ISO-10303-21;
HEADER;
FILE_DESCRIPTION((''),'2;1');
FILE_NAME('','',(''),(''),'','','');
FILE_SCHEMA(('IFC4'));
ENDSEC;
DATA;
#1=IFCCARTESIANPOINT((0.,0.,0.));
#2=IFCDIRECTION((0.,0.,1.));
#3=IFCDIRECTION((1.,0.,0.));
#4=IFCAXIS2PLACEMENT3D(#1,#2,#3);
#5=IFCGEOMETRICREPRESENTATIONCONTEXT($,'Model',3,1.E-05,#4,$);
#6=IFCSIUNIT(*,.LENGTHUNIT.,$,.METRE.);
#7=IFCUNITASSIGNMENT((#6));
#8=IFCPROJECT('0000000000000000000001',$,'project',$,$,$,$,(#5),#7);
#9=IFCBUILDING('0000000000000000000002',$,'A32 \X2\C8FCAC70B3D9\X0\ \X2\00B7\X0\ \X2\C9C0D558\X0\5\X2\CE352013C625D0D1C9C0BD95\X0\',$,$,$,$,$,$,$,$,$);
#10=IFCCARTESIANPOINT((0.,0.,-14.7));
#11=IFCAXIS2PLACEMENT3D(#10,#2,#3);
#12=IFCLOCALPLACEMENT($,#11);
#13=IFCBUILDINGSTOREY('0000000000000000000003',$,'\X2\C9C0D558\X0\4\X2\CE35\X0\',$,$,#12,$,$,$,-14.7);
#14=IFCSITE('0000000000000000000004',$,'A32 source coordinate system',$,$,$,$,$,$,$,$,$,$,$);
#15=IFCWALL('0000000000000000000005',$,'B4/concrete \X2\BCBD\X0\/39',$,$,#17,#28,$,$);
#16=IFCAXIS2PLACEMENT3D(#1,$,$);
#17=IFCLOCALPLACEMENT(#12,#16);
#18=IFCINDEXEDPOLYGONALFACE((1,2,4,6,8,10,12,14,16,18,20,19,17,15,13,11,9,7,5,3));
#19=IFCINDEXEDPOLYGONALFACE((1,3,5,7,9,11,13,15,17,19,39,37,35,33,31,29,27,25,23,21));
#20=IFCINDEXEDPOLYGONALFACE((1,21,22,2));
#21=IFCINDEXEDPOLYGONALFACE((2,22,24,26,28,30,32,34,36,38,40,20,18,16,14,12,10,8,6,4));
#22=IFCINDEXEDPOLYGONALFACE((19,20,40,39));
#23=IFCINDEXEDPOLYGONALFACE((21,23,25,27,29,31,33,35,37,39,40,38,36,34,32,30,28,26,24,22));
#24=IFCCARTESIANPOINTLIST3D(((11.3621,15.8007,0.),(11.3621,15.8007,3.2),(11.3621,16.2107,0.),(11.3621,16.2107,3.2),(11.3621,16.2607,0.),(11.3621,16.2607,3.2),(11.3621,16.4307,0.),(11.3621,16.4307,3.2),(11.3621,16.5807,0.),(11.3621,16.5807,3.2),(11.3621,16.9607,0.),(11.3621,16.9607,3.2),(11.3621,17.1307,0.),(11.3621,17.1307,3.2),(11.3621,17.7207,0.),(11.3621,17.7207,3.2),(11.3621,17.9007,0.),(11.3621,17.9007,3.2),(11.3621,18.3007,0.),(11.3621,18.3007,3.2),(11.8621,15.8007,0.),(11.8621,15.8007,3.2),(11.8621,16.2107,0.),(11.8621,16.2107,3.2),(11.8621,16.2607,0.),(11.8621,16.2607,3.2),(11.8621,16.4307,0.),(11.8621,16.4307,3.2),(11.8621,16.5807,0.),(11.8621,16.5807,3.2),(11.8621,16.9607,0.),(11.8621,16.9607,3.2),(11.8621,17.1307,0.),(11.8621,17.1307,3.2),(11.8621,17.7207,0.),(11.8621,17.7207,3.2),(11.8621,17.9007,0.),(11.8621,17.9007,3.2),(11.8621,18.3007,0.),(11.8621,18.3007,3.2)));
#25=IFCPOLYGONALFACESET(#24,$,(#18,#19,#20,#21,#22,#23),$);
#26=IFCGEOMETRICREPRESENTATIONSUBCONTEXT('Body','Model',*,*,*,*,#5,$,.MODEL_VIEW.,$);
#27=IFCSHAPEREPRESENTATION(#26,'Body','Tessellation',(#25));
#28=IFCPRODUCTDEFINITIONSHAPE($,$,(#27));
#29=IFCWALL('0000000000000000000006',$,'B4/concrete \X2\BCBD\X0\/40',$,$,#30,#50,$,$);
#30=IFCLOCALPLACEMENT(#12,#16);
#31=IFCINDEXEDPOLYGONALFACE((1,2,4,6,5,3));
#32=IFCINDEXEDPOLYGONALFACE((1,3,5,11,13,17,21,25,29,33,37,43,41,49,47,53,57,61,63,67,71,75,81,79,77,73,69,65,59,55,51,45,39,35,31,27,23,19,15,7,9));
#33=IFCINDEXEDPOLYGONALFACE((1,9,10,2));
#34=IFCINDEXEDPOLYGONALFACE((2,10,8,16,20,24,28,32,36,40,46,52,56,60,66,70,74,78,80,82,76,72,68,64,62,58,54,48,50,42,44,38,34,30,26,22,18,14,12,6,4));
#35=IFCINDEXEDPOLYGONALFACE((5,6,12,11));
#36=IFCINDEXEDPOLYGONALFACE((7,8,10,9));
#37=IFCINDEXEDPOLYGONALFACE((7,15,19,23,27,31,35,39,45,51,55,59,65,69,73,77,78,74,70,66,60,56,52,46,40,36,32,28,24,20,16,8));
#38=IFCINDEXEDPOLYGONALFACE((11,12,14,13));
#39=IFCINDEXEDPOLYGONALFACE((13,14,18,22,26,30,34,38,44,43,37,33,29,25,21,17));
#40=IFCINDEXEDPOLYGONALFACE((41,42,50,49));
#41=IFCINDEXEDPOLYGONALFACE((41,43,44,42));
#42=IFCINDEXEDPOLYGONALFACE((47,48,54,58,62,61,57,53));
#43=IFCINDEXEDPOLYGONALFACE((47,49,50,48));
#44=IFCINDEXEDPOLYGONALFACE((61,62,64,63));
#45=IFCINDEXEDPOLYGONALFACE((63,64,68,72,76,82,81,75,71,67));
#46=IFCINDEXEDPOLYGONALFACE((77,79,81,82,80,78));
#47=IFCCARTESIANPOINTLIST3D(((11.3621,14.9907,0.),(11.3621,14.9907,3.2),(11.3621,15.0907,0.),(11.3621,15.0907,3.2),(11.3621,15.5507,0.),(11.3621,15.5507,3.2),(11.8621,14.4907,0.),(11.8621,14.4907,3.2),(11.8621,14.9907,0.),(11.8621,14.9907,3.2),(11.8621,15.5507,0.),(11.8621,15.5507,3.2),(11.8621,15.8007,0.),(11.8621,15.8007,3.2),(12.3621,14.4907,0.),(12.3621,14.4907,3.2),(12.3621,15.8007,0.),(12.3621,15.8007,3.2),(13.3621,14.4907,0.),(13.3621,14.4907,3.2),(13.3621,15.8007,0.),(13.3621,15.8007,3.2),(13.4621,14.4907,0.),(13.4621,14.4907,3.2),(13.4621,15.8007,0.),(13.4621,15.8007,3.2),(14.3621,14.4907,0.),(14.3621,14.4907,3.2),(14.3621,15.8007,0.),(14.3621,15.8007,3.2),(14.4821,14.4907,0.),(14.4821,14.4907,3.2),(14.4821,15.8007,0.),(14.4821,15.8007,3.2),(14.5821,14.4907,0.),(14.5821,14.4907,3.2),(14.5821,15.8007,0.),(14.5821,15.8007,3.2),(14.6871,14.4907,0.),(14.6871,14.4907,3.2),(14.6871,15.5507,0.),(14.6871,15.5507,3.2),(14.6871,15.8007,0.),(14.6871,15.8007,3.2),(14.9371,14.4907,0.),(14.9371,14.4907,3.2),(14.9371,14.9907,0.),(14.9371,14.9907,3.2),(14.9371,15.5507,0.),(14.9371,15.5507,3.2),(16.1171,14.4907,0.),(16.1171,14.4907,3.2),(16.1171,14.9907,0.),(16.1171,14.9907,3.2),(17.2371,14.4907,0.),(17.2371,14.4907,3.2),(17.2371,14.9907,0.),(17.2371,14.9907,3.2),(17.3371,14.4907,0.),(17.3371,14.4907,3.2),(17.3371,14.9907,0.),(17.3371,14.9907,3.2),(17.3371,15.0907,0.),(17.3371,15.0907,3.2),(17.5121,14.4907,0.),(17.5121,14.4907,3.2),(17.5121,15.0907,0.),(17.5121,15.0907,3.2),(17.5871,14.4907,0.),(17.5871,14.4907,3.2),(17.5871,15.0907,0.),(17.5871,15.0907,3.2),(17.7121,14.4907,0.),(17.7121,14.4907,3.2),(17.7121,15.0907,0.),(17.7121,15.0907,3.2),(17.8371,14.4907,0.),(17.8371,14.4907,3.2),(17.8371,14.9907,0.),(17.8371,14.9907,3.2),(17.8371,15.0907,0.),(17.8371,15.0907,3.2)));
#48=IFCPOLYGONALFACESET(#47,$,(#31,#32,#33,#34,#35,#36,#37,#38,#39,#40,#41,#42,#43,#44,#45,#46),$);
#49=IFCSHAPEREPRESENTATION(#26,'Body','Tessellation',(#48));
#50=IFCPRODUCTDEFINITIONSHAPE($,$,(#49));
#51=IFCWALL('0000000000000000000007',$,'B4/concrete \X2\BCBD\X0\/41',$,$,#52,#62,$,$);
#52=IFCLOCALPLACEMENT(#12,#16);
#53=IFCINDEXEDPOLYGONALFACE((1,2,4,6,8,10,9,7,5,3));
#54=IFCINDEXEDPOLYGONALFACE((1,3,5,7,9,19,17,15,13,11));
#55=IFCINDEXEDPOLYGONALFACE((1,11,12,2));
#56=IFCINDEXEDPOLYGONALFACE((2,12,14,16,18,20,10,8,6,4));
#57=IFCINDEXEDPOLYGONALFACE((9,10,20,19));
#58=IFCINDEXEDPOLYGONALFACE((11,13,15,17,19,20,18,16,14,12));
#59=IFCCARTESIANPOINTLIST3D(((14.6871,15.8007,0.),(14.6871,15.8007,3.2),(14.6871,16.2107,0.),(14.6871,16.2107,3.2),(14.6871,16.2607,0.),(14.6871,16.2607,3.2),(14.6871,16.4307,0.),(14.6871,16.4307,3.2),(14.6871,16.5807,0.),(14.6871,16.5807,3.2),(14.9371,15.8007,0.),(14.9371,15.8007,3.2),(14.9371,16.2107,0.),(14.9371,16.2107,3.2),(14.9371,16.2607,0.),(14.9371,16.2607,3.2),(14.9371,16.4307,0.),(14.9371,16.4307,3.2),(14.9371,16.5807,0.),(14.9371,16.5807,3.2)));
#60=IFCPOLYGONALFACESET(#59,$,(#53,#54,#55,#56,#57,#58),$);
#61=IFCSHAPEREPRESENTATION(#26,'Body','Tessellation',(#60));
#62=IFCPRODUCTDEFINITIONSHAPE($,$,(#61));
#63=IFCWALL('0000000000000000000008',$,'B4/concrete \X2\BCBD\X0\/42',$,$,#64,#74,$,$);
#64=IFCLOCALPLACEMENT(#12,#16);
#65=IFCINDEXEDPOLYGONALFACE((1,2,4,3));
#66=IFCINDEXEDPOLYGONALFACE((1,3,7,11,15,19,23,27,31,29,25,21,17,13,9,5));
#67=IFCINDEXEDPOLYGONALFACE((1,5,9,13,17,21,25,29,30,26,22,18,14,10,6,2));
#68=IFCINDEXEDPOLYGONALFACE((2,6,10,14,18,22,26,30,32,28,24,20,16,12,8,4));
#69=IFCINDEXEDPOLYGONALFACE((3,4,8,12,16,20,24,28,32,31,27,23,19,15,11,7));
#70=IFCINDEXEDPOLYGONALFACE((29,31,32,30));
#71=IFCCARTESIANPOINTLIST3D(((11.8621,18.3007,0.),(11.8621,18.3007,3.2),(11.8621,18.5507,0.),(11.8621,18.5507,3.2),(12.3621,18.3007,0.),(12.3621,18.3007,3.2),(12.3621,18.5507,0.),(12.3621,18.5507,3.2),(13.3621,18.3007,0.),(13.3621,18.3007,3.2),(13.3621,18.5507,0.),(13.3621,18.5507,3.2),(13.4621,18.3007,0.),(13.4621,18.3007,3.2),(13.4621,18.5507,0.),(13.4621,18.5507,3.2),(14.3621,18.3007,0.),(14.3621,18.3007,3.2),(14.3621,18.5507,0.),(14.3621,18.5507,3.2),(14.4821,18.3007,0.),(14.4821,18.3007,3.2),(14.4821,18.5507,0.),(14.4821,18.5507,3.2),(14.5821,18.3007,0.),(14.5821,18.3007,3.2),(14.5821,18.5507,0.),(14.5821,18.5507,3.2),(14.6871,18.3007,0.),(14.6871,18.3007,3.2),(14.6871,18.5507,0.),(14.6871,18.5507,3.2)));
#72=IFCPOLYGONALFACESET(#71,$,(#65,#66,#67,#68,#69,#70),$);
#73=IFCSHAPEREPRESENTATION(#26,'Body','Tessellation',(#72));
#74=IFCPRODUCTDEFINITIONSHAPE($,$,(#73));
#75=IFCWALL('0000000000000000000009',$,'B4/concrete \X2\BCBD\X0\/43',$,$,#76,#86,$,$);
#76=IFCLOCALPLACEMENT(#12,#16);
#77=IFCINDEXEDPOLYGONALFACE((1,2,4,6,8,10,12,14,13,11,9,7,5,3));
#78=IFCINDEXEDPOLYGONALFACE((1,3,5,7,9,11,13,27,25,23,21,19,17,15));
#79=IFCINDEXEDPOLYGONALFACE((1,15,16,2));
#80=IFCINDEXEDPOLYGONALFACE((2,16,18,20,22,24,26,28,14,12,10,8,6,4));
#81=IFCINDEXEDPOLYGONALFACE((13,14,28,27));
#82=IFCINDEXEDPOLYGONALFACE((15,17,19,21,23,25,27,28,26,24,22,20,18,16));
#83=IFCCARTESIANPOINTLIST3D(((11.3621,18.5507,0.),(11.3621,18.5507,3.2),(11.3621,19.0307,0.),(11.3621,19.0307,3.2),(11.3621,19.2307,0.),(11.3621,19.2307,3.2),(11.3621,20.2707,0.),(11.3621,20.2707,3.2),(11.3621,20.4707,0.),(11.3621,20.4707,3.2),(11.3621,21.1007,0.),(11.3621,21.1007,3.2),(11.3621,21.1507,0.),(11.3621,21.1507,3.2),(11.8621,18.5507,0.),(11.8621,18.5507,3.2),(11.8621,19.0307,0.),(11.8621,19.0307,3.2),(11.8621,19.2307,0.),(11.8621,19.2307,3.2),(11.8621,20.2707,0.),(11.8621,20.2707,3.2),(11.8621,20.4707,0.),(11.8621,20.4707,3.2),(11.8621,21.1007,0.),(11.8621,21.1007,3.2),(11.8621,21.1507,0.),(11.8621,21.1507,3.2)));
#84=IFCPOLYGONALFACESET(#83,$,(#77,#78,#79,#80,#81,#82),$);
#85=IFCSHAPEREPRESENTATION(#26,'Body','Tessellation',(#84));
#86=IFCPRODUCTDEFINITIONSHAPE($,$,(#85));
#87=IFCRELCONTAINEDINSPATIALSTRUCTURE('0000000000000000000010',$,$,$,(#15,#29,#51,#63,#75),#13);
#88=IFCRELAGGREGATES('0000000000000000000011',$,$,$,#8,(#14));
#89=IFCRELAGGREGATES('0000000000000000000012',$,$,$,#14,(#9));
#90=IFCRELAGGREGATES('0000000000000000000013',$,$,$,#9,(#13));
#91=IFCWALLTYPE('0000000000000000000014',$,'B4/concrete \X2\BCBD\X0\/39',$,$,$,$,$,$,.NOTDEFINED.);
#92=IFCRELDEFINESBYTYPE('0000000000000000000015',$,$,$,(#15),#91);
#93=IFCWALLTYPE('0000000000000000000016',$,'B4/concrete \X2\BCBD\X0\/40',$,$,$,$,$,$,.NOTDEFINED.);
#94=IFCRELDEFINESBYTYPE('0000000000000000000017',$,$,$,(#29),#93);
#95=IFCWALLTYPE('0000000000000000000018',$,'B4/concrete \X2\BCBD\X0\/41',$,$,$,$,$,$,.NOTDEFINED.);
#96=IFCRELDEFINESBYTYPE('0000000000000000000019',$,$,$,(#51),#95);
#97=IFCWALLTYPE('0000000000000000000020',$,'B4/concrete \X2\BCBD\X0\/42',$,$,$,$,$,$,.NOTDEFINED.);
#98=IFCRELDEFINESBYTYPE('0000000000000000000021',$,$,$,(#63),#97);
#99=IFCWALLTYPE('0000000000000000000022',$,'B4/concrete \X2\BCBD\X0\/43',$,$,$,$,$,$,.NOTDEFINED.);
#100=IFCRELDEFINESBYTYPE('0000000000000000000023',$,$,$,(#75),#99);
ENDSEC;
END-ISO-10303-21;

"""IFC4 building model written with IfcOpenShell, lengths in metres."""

from ifc_helpers import new_model, si_unit, frame, origin, origin_with_axes, place, context, subcontext, project, spatial, polyline, outline, extrude, source, transform, mapped, type_object, type_shapes, element, save


model = new_model("IFC4")

# Units and contexts
model_context = context("Model", 3, precision=1e-05, world=origin_with_axes())
body_context = subcontext(model_context, "Body", "Model", "MODEL_VIEW")
ifc_project = project(units=[si_unit("LENGTHUNIT", "METRE")], contexts=[model_context])

# Site, building, storey
site = spatial("IfcSite", under=ifc_project, Name="A32 source coordinate system")
building = spatial("IfcBuilding", under=site, Name="A32 주거동 · 지하5층–옥탑지붕")
storey_placement = place(None, frame((0.0, 0.0, -14.7), z_axis=(0.0, 0.0, 1.0), x_axis=(1.0, 0.0, 0.0)))
storey = spatial("IfcBuildingStorey", under=building, at=storey_placement, Name="지하4층", Elevation=-14.7)

# Walls
wall_type_1 = type_object("IfcWallType", Name="B4/concrete 벽/39", PredefinedType="NOTDEFINED")
shared_shape_1 = source(origin(), body_context, "Body", "SweptSolid", [
    extrude(outline(polyline([(11.3621, 16.9607), (11.3621, 17.1307), (11.3621, 17.7207), (11.3621, 17.9007), (11.3621, 18.3007), (11.8621, 18.3007), (11.8621, 17.9007), (11.8621, 17.7207), (11.8621, 17.1307), (11.8621, 16.9607), (11.8621, 16.5807), (11.8621, 16.4307), (11.8621, 16.2607), (11.8621, 16.2107), (11.8621, 15.8007), (11.3621, 15.8007), (11.3621, 16.2107), (11.3621, 16.2607), (11.3621, 16.4307), (11.3621, 16.5807), (11.3621, 16.9607)])), origin(), (0.0, 0.0, 1.0), 3.2),
])
type_shapes(wall_type_1, [shared_shape_1])
wall_1_placement = place(storey_placement, origin_with_axes())
element("IfcWall", 1, at=wall_1_placement, inside=storey, type_object=wall_type_1, Name="B4/concrete 벽/39", context=body_context, shape_type="MappedRepresentation", body=[
    mapped(shared_shape_1, transform((0.0, 0.0, 0.0), scale=1.0)),
])
wall_type_2 = type_object("IfcWallType", Name="B4/concrete 벽/40", PredefinedType="NOTDEFINED")
shared_shape_2 = source(origin(), body_context, "Body", "SweptSolid", [
    extrude(outline(polyline([(13.4621, 15.8007), (14.3621, 15.8007), (14.4821, 15.8007), (14.5821, 15.8007), (14.6871, 15.8007), (14.6871, 15.5507), (14.9371, 15.5507), (14.9371, 14.9907), (16.1171, 14.9907), (17.2371, 14.9907), (17.3371, 14.9907), (17.3371, 15.0907), (17.5121, 15.0907), (17.5871, 15.0907), (17.7121, 15.0907), (17.8371, 15.0907), (17.8371, 14.9907), (17.8371, 14.4907), (17.7121, 14.4907), (17.5871, 14.4907), (17.5121, 14.4907), (17.3371, 14.4907), (17.2371, 14.4907), (16.1171, 14.4907), (14.9371, 14.4907), (14.6871, 14.4907), (14.5821, 14.4907), (14.4821, 14.4907), (14.3621, 14.4907), (13.4621, 14.4907), (13.3621, 14.4907), (12.3621, 14.4907), (11.8621, 14.4907), (11.8621, 14.9907), (11.3621, 14.9907), (11.3621, 15.0907), (11.3621, 15.5507), (11.8621, 15.5507), (11.8621, 15.8007), (12.3621, 15.8007), (13.3621, 15.8007), (13.4621, 15.8007)])), origin(), (0.0, 0.0, 1.0), 3.2),
])
type_shapes(wall_type_2, [shared_shape_2])
wall_2_placement = place(storey_placement, origin_with_axes())
element("IfcWall", 2, at=wall_2_placement, inside=storey, type_object=wall_type_2, Name="B4/concrete 벽/40", context=body_context, shape_type="MappedRepresentation", body=[
    mapped(shared_shape_2, transform((0.0, 0.0, 0.0), scale=1.0)),
])
wall_type_3 = type_object("IfcWallType", Name="B4/concrete 벽/41", PredefinedType="NOTDEFINED")
shared_shape_3 = source(origin(), body_context, "Body", "SweptSolid", [
    extrude(outline(polyline([(14.6871, 16.4307), (14.6871, 16.5807), (14.9371, 16.5807), (14.9371, 16.4307), (14.9371, 16.2607), (14.9371, 16.2107), (14.9371, 15.8007), (14.6871, 15.8007), (14.6871, 16.2107), (14.6871, 16.2607), (14.6871, 16.4307)])), origin(), (0.0, 0.0, 1.0), 3.2),
])
type_shapes(wall_type_3, [shared_shape_3])
wall_3_placement = place(storey_placement, origin_with_axes())
element("IfcWall", 3, at=wall_3_placement, inside=storey, type_object=wall_type_3, Name="B4/concrete 벽/41", context=body_context, shape_type="MappedRepresentation", body=[
    mapped(shared_shape_3, transform((0.0, 0.0, 0.0), scale=1.0)),
])
wall_type_4 = type_object("IfcWallType", Name="B4/concrete 벽/42", PredefinedType="NOTDEFINED")
shared_shape_4 = source(origin(), body_context, "Body", "SweptSolid", [
    extrude(outline(polyline([(13.3621, 18.5507), (13.4621, 18.5507), (14.3621, 18.5507), (14.4821, 18.5507), (14.5821, 18.5507), (14.6871, 18.5507), (14.6871, 18.3007), (14.5821, 18.3007), (14.4821, 18.3007), (14.3621, 18.3007), (13.4621, 18.3007), (13.3621, 18.3007), (12.3621, 18.3007), (11.8621, 18.3007), (11.8621, 18.5507), (12.3621, 18.5507), (13.3621, 18.5507)])), origin(), (0.0, 0.0, 1.0), 3.2),
])
type_shapes(wall_type_4, [shared_shape_4])
wall_4_placement = place(storey_placement, origin_with_axes())
element("IfcWall", 4, at=wall_4_placement, inside=storey, type_object=wall_type_4, Name="B4/concrete 벽/42", context=body_context, shape_type="MappedRepresentation", body=[
    mapped(shared_shape_4, transform((0.0, 0.0, 0.0), scale=1.0)),
])
wall_type_5 = type_object("IfcWallType", Name="B4/concrete 벽/43", PredefinedType="NOTDEFINED")
shared_shape_5 = source(origin(), body_context, "Body", "SweptSolid", [
    extrude(outline(polyline([(11.3621, 19.2307), (11.3621, 20.2707), (11.3621, 20.4707), (11.3621, 21.1007), (11.3621, 21.1507), (11.8621, 21.1507), (11.8621, 21.1007), (11.8621, 20.4707), (11.8621, 20.2707), (11.8621, 19.2307), (11.8621, 19.0307), (11.8621, 18.5507), (11.3621, 18.5507), (11.3621, 19.0307), (11.3621, 19.2307)])), origin(), (0.0, 0.0, 1.0), 3.2),
])
type_shapes(wall_type_5, [shared_shape_5])
wall_5_placement = place(storey_placement, origin_with_axes())
element("IfcWall", 5, at=wall_5_placement, inside=storey, type_object=wall_type_5, Name="B4/concrete 벽/43", context=body_context, shape_type="MappedRepresentation", body=[
    mapped(shared_shape_5, transform((0.0, 0.0, 0.0), scale=1.0)),
])

save(model, "model.ifc")
